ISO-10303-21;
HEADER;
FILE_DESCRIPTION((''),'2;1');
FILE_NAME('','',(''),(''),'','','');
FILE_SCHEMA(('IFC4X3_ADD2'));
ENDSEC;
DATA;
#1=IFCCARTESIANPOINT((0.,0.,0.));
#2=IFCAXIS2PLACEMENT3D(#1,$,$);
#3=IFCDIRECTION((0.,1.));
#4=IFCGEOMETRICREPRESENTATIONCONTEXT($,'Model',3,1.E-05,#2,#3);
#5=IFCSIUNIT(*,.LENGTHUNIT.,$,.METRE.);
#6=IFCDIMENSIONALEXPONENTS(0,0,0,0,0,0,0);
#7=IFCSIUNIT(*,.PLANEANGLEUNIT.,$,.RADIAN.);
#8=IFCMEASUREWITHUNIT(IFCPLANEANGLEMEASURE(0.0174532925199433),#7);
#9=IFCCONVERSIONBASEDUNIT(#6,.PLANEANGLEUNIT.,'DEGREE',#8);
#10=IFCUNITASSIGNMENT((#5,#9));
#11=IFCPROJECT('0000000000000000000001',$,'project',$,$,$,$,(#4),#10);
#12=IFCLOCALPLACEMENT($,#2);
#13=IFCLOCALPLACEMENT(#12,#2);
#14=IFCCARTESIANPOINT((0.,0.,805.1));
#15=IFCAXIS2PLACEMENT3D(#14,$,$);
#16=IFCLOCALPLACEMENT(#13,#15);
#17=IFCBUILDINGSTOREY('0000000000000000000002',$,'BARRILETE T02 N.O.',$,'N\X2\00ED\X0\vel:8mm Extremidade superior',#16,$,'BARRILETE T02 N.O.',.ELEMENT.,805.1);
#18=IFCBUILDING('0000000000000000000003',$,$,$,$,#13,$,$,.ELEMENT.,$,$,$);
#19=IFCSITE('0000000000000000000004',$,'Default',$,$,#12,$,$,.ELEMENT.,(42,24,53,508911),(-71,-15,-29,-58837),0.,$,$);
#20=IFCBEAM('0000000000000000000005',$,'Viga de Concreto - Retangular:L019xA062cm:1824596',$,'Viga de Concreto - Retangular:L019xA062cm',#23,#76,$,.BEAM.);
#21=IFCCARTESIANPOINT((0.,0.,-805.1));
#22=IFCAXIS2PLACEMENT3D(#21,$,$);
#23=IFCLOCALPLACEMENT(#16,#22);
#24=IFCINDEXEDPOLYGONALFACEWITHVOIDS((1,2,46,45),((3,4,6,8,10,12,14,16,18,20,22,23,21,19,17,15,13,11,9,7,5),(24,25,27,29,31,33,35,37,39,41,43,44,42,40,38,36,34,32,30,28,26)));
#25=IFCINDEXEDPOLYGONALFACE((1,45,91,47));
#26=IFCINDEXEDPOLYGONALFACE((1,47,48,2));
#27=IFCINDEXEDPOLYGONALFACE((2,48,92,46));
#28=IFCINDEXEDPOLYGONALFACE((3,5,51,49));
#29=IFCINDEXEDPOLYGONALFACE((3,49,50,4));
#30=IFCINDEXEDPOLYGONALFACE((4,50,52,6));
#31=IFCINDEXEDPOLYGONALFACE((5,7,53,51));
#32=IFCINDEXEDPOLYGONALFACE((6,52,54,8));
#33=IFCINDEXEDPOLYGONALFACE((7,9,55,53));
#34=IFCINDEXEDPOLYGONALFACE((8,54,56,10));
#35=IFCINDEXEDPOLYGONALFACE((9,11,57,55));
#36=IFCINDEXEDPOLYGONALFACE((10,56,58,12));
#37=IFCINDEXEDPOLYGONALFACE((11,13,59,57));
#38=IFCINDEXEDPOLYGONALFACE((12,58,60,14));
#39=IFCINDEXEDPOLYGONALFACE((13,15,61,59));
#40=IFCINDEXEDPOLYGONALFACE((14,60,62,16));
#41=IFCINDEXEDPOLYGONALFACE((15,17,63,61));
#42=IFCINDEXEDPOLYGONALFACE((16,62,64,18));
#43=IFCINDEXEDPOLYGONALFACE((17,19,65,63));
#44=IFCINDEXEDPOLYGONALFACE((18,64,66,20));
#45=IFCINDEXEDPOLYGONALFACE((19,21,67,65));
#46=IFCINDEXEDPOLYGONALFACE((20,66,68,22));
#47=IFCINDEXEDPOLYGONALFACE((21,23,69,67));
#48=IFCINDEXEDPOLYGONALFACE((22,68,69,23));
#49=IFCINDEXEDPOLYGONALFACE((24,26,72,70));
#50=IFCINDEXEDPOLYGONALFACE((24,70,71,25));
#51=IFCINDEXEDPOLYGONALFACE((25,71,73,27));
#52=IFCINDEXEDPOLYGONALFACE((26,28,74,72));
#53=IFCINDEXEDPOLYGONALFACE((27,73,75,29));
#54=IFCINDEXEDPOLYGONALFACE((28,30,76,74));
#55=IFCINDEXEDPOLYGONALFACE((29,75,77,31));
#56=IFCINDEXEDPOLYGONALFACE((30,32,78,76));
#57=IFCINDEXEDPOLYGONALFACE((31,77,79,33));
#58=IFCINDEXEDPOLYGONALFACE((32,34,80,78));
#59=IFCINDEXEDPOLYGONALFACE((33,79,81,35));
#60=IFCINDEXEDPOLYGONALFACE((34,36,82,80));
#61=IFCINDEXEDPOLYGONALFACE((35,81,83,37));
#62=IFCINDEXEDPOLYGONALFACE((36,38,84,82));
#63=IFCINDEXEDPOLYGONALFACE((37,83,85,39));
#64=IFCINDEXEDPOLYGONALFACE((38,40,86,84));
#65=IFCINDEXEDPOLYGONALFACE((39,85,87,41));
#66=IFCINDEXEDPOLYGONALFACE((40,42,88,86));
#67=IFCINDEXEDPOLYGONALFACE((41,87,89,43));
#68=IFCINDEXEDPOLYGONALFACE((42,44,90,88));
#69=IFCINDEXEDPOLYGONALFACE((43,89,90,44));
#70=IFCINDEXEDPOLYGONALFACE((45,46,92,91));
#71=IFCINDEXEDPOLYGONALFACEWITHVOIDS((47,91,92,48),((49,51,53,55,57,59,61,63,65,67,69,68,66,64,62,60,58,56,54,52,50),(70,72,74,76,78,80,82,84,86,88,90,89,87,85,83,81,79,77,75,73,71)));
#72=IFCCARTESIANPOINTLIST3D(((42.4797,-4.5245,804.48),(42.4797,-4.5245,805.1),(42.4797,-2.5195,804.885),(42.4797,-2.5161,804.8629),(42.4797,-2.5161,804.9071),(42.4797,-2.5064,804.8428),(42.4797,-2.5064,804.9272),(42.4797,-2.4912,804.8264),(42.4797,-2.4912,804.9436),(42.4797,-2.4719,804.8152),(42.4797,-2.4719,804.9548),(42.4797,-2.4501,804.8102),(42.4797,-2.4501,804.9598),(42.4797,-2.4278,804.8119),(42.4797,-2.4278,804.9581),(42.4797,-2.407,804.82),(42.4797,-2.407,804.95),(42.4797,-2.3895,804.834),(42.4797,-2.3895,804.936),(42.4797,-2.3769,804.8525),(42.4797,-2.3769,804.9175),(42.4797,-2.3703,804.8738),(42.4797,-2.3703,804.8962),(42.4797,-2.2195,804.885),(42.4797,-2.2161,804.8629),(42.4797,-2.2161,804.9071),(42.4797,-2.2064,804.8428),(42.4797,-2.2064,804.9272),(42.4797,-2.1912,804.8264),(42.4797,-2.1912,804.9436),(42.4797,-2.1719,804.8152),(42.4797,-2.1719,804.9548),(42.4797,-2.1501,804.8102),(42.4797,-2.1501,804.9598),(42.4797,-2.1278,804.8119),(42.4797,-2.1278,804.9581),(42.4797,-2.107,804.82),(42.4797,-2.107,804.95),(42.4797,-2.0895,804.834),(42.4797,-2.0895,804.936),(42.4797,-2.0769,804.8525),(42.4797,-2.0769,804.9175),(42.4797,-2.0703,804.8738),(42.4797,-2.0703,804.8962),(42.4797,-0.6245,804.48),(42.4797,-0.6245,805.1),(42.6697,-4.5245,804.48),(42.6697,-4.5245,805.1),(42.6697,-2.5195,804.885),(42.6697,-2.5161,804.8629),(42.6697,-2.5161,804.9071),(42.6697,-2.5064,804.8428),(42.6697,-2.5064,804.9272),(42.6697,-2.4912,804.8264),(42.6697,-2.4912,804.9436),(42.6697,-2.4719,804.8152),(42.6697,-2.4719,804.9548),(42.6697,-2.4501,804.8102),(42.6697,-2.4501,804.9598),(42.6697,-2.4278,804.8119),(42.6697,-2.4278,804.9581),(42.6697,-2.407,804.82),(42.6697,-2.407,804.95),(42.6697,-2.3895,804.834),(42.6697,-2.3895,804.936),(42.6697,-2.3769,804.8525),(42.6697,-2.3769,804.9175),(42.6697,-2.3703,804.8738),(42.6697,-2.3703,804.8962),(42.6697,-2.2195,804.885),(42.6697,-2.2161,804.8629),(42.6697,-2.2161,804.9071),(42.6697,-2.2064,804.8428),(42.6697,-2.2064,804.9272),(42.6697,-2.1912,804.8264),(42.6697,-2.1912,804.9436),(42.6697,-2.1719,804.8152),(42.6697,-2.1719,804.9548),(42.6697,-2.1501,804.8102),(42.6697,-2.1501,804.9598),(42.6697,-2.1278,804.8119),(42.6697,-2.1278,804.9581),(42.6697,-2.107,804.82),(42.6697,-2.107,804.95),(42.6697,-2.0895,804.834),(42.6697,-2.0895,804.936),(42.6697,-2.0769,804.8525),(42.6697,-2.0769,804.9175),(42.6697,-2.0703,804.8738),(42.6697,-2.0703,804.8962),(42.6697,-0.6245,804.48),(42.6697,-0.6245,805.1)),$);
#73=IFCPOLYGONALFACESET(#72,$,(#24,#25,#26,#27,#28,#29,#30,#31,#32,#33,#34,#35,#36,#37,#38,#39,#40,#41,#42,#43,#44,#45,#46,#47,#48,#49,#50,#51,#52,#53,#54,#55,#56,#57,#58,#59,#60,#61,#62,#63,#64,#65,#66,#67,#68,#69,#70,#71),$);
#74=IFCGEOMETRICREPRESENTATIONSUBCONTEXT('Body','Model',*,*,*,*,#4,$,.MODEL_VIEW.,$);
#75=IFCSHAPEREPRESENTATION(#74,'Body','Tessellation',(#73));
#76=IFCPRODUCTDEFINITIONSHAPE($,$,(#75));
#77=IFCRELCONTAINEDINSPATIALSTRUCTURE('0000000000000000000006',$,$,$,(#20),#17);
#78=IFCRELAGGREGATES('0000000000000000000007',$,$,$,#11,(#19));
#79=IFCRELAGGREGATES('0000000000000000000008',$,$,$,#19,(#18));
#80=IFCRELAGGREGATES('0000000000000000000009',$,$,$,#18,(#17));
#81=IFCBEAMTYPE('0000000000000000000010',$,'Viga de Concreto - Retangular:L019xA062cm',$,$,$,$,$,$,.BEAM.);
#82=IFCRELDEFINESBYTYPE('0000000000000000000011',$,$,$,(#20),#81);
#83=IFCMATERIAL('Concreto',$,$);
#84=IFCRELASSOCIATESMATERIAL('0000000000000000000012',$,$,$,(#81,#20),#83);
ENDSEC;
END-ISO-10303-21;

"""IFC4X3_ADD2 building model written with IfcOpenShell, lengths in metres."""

from ifc_helpers import new_model, entity, si_unit, converted_unit, direction, frame, frame_2d, origin, origin_2d_with_axis, place, context, subcontext, project, spatial, rectangle, circle, extrude, boolean, source, transform, mapped, material, material_profile, profile_set, type_object, type_shapes, element, save


model = new_model("IFC4X3_ADD2")

# Units and contexts
model_context = context("Model", 3, precision=1e-05, world=origin(), true_north=direction((0.0, 1.0)))
body_context = subcontext(model_context, "Body", "Model", "MODEL_VIEW")
ifc_project = project(units=[si_unit("LENGTHUNIT", "METRE"), converted_unit("PLANEANGLEUNIT", "DEGREE", entity("IfcPlaneAngleMeasure", 0.0174532925199433), si_unit("PLANEANGLEUNIT", "RADIAN"), dimensions=[0, 0, 0, 0, 0, 0, 0])], contexts=[model_context])

# Site, building, storey
site_placement = place(None, origin())
site = spatial("IfcSite", under=ifc_project, at=site_placement, Name="Default", CompositionType="ELEMENT", RefLatitude=(42, 24, 53, 508911), RefLongitude=(-71, -15, -29, -58837), RefElevation=0.0)
building_placement = place(site_placement, origin())
building = spatial("IfcBuilding", under=site, at=building_placement, CompositionType="ELEMENT")
storey_placement = place(building_placement, frame((0.0, 0.0, 805.1)))
storey = spatial("IfcBuildingStorey", under=building, at=storey_placement, Name="BARRILETE T02 N.O.", ObjectType="Nível:8mm Extremidade superior", LongName="BARRILETE T02 N.O.", CompositionType="ELEMENT", Elevation=805.1)

# Shared definitions
ifc_material = material(Name="Concreto")

# Beam
ifc_material_profile_1 = material_profile(ifc_material, rectangle(XDim=0.62, YDim=0.19, at=frame_2d((0.0, 0.0), x_axis=(0.0, 1.0))), Name="L019xA062cm")
ifc_profile_set_1 = profile_set([ifc_material_profile_1], Name="L019xA062cm")
beam_type_1 = type_object("IfcBeamType", Name="Viga de Concreto - Retangular:L019xA062cm", PredefinedType="BEAM", material=ifc_profile_set_1)
shared_shape_1 = source(origin(), body_context, "Body", "CSG", [
    boolean("DIFFERENCE", boolean("DIFFERENCE", extrude(rectangle(XDim=0.62, YDim=0.19, at=frame_2d((0.0, 0.0), x_axis=(0.0, 1.0))), frame((42.5747, -4.5245, 804.79), z_axis=(0.0, 1.0, 0.0), x_axis=(-1.0, 0.0, 0.0)), (0.0, 0.0, 1.0), 3.9), extrude(circle(Radius=0.075, at=origin_2d_with_axis()), frame((42.6697, -2.4445, 804.885), z_axis=(-1.0, 0.0, 0.0), x_axis=(0.0, -1.0, 0.0)), (0.0, 0.0, 1.0), 0.19)), extrude(circle(Radius=0.075, at=origin_2d_with_axis()), frame((42.4797, -2.1445, 804.885), z_axis=(1.0, 0.0, 0.0), x_axis=(0.0, -1.0, 0.0)), (0.0, 0.0, 1.0), 0.19)),
])
type_shapes(beam_type_1, [shared_shape_1])
beam_1_placement = place(storey_placement, frame((0.0, 0.0, -805.1)))
element("IfcBeam", 1, at=beam_1_placement, inside=storey, type_object=beam_type_1, material=ifc_material, Name="Viga de Concreto - Retangular:L019xA062cm:1824596", ObjectType="Viga de Concreto - Retangular:L019xA062cm", PredefinedType="BEAM", context=body_context, shape_type="MappedRepresentation", body=[
    mapped(shared_shape_1, transform((0.0, 0.0, 0.0), scale=1.0)),
])

save(model, "model.ifc")
